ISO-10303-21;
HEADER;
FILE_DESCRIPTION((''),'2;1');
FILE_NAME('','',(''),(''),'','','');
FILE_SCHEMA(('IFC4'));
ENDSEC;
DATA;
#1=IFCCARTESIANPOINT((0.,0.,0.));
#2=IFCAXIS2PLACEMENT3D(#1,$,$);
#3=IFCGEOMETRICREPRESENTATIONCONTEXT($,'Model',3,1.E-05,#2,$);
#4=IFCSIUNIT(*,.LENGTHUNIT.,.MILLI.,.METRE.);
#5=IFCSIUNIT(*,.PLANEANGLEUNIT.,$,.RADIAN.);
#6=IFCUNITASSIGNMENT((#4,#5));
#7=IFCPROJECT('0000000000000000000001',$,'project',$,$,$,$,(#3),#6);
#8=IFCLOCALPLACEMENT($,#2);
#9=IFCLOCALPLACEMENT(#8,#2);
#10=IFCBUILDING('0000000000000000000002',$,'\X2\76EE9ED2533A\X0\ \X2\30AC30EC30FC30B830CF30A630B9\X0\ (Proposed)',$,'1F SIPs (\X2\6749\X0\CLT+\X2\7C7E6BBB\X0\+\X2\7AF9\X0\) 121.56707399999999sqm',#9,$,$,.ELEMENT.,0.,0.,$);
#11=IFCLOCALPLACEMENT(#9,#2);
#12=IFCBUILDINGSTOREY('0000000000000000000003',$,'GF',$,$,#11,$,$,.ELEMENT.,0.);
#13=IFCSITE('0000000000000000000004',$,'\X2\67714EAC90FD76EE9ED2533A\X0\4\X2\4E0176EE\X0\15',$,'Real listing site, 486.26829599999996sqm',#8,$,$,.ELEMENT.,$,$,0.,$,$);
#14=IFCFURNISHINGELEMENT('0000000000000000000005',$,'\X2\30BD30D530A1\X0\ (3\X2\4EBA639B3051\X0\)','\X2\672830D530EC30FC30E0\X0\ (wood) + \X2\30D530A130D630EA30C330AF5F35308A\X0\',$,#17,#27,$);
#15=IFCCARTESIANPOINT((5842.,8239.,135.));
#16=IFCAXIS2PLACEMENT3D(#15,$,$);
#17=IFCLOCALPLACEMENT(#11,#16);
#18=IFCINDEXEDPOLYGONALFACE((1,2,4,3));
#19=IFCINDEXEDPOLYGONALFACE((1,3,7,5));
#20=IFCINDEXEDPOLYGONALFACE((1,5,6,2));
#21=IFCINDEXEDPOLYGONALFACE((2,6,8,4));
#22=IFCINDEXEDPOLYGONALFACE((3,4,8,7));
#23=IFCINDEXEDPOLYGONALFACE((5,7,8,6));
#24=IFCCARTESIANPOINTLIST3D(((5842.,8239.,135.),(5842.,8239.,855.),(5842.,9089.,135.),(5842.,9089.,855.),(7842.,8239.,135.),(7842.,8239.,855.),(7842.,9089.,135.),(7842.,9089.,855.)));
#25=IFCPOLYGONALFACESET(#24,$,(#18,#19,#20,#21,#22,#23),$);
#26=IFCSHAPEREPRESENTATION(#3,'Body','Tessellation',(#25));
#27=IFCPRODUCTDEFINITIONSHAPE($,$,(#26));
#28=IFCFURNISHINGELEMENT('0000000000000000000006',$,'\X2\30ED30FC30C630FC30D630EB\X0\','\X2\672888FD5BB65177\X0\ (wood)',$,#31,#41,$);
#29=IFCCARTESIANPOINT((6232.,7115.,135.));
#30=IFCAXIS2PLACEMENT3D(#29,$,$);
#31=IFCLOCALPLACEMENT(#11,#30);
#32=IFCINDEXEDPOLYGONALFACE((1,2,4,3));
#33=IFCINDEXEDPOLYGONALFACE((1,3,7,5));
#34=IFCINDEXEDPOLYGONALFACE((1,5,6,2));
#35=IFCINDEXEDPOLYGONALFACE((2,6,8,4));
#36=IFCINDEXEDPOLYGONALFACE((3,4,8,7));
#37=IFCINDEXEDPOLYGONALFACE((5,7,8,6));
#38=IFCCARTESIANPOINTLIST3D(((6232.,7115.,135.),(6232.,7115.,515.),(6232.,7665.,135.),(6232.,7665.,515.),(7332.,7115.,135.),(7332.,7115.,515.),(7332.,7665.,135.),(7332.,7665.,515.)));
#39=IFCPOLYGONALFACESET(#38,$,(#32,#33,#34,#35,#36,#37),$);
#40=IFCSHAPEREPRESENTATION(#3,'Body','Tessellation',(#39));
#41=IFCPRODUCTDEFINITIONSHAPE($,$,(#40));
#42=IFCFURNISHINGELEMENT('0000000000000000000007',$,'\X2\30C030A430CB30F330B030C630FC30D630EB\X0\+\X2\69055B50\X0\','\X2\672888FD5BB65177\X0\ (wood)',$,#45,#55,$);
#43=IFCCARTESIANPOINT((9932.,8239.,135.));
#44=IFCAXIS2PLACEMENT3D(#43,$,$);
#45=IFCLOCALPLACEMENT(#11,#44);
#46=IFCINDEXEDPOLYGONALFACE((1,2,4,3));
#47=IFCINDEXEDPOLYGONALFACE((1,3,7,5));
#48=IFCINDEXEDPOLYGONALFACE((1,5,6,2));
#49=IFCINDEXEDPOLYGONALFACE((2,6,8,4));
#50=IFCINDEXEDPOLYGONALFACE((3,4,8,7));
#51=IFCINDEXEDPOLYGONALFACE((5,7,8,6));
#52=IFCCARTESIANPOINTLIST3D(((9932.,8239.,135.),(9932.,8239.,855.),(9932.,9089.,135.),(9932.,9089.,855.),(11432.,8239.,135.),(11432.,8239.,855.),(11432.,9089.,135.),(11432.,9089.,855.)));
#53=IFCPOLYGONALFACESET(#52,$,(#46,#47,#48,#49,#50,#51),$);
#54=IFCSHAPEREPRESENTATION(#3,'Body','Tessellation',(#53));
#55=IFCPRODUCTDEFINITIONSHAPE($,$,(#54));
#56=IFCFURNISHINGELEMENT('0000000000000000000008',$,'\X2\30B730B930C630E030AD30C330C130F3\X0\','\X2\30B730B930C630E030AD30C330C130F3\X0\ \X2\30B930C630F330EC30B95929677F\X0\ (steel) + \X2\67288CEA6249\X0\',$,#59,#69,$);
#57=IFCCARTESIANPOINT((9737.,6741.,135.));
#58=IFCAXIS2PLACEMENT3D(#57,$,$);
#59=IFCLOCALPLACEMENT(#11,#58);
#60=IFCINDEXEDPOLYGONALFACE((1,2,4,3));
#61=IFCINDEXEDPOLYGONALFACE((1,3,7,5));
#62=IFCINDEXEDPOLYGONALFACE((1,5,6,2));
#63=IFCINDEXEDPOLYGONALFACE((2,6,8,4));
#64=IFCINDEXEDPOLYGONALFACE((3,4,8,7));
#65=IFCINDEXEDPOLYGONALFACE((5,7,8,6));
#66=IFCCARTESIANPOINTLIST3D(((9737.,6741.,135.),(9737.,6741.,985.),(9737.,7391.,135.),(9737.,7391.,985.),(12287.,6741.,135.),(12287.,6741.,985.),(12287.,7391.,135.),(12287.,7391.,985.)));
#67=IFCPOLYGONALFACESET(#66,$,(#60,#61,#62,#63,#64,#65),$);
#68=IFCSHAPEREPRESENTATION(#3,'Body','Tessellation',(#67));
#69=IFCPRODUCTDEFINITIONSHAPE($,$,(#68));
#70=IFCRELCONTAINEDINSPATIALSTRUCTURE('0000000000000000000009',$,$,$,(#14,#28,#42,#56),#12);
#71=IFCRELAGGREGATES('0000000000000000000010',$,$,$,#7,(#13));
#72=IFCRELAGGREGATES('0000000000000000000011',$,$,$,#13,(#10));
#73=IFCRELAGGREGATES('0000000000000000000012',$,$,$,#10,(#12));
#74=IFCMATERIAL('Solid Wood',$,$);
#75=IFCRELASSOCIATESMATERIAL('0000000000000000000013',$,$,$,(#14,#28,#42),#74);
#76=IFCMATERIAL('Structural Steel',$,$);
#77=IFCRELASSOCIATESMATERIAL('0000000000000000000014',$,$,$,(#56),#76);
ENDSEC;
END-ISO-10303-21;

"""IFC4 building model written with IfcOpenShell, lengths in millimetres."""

from ifc_helpers import new_model, si_unit, frame, frame_2d, origin, place, context, project, spatial, rectangle, extrude, material, element, save


model = new_model("IFC4")

# Units and contexts
model_context = context("Model", 3, precision=1e-05, world=origin())
ifc_project = project(units=[si_unit("LENGTHUNIT", "METRE", prefix="MILLI"), si_unit("PLANEANGLEUNIT", "RADIAN")], contexts=[model_context])

# Site, building, storey
site_placement = place(None, origin())
site = spatial("IfcSite", under=ifc_project, at=site_placement, Name="東京都目黒区4丁目15", ObjectType="Real listing site, 486.26829599999996sqm", CompositionType="ELEMENT", RefElevation=0.0)
building_placement = place(site_placement, origin())
building = spatial("IfcBuilding", under=site, at=building_placement, Name="目黒区 ガレージハウス (Proposed)", ObjectType="1F SIPs (杉CLT+籾殻+竹) 121.56707399999999sqm", CompositionType="ELEMENT", ElevationOfRefHeight=0.0, ElevationOfTerrain=0.0)
storey_placement = place(building_placement, origin())
storey = spatial("IfcBuildingStorey", under=building, at=storey_placement, Name="GF", CompositionType="ELEMENT", Elevation=0.0)

# Shared definitions
ifc_material_1 = material(Name="Solid Wood")

# Shared definitions
ifc_material_2 = material(Name="Structural Steel")

# Furnishing elements
furnishing_1_placement = place(storey_placement, frame((5842.0, 8239.0, 135.0)))
element("IfcFurnishingElement", 1, at=furnishing_1_placement, inside=storey, material=ifc_material_1, Name="ソファ (3人掛け)", Description="木フレーム (wood) + ファブリック張り", context=model_context, shape_type="SweptSolid", body=[
    extrude(rectangle(XDim=2000.0, YDim=850.0, at=frame_2d((1000.0, 425.0))), frame((5842.0, 8239.0, 135.0)), (0.0, 0.0, 1.0), 720.0),
])
furnishing_2_placement = place(storey_placement, frame((6232.0, 7115.0, 135.0)))
element("IfcFurnishingElement", 2, at=furnishing_2_placement, inside=storey, material=ifc_material_1, Name="ローテーブル", Description="木製家具 (wood)", context=model_context, shape_type="SweptSolid", body=[
    extrude(rectangle(XDim=1100.0, YDim=550.0, at=frame_2d((550.0, 275.0))), frame((6232.0, 7115.0, 135.0)), (0.0, 0.0, 1.0), 380.0),
])
furnishing_3_placement = place(storey_placement, frame((9932.0, 8239.0, 135.0)))
element("IfcFurnishingElement", 3, at=furnishing_3_placement, inside=storey, material=ifc_material_1, Name="ダイニングテーブル+椅子", Description="木製家具 (wood)", context=model_context, shape_type="SweptSolid", body=[
    extrude(rectangle(XDim=1500.0, YDim=850.0, at=frame_2d((750.0, 425.0))), frame((9932.0, 8239.0, 135.0)), (0.0, 0.0, 1.0), 720.0),
])
furnishing_4_placement = place(storey_placement, frame((9737.0, 6741.0, 135.0)))
element("IfcFurnishingElement", 4, at=furnishing_4_placement, inside=storey, material=ifc_material_2, Name="システムキッチン", Description="システムキッチン ステンレス天板 (steel) + 木質扉", context=model_context, shape_type="SweptSolid", body=[
    extrude(rectangle(XDim=2550.0, YDim=650.0, at=frame_2d((1275.0, 325.0))), frame((9737.0, 6741.0, 135.0)), (0.0, 0.0, 1.0), 850.0),
])

save(model, "model.ifc")
